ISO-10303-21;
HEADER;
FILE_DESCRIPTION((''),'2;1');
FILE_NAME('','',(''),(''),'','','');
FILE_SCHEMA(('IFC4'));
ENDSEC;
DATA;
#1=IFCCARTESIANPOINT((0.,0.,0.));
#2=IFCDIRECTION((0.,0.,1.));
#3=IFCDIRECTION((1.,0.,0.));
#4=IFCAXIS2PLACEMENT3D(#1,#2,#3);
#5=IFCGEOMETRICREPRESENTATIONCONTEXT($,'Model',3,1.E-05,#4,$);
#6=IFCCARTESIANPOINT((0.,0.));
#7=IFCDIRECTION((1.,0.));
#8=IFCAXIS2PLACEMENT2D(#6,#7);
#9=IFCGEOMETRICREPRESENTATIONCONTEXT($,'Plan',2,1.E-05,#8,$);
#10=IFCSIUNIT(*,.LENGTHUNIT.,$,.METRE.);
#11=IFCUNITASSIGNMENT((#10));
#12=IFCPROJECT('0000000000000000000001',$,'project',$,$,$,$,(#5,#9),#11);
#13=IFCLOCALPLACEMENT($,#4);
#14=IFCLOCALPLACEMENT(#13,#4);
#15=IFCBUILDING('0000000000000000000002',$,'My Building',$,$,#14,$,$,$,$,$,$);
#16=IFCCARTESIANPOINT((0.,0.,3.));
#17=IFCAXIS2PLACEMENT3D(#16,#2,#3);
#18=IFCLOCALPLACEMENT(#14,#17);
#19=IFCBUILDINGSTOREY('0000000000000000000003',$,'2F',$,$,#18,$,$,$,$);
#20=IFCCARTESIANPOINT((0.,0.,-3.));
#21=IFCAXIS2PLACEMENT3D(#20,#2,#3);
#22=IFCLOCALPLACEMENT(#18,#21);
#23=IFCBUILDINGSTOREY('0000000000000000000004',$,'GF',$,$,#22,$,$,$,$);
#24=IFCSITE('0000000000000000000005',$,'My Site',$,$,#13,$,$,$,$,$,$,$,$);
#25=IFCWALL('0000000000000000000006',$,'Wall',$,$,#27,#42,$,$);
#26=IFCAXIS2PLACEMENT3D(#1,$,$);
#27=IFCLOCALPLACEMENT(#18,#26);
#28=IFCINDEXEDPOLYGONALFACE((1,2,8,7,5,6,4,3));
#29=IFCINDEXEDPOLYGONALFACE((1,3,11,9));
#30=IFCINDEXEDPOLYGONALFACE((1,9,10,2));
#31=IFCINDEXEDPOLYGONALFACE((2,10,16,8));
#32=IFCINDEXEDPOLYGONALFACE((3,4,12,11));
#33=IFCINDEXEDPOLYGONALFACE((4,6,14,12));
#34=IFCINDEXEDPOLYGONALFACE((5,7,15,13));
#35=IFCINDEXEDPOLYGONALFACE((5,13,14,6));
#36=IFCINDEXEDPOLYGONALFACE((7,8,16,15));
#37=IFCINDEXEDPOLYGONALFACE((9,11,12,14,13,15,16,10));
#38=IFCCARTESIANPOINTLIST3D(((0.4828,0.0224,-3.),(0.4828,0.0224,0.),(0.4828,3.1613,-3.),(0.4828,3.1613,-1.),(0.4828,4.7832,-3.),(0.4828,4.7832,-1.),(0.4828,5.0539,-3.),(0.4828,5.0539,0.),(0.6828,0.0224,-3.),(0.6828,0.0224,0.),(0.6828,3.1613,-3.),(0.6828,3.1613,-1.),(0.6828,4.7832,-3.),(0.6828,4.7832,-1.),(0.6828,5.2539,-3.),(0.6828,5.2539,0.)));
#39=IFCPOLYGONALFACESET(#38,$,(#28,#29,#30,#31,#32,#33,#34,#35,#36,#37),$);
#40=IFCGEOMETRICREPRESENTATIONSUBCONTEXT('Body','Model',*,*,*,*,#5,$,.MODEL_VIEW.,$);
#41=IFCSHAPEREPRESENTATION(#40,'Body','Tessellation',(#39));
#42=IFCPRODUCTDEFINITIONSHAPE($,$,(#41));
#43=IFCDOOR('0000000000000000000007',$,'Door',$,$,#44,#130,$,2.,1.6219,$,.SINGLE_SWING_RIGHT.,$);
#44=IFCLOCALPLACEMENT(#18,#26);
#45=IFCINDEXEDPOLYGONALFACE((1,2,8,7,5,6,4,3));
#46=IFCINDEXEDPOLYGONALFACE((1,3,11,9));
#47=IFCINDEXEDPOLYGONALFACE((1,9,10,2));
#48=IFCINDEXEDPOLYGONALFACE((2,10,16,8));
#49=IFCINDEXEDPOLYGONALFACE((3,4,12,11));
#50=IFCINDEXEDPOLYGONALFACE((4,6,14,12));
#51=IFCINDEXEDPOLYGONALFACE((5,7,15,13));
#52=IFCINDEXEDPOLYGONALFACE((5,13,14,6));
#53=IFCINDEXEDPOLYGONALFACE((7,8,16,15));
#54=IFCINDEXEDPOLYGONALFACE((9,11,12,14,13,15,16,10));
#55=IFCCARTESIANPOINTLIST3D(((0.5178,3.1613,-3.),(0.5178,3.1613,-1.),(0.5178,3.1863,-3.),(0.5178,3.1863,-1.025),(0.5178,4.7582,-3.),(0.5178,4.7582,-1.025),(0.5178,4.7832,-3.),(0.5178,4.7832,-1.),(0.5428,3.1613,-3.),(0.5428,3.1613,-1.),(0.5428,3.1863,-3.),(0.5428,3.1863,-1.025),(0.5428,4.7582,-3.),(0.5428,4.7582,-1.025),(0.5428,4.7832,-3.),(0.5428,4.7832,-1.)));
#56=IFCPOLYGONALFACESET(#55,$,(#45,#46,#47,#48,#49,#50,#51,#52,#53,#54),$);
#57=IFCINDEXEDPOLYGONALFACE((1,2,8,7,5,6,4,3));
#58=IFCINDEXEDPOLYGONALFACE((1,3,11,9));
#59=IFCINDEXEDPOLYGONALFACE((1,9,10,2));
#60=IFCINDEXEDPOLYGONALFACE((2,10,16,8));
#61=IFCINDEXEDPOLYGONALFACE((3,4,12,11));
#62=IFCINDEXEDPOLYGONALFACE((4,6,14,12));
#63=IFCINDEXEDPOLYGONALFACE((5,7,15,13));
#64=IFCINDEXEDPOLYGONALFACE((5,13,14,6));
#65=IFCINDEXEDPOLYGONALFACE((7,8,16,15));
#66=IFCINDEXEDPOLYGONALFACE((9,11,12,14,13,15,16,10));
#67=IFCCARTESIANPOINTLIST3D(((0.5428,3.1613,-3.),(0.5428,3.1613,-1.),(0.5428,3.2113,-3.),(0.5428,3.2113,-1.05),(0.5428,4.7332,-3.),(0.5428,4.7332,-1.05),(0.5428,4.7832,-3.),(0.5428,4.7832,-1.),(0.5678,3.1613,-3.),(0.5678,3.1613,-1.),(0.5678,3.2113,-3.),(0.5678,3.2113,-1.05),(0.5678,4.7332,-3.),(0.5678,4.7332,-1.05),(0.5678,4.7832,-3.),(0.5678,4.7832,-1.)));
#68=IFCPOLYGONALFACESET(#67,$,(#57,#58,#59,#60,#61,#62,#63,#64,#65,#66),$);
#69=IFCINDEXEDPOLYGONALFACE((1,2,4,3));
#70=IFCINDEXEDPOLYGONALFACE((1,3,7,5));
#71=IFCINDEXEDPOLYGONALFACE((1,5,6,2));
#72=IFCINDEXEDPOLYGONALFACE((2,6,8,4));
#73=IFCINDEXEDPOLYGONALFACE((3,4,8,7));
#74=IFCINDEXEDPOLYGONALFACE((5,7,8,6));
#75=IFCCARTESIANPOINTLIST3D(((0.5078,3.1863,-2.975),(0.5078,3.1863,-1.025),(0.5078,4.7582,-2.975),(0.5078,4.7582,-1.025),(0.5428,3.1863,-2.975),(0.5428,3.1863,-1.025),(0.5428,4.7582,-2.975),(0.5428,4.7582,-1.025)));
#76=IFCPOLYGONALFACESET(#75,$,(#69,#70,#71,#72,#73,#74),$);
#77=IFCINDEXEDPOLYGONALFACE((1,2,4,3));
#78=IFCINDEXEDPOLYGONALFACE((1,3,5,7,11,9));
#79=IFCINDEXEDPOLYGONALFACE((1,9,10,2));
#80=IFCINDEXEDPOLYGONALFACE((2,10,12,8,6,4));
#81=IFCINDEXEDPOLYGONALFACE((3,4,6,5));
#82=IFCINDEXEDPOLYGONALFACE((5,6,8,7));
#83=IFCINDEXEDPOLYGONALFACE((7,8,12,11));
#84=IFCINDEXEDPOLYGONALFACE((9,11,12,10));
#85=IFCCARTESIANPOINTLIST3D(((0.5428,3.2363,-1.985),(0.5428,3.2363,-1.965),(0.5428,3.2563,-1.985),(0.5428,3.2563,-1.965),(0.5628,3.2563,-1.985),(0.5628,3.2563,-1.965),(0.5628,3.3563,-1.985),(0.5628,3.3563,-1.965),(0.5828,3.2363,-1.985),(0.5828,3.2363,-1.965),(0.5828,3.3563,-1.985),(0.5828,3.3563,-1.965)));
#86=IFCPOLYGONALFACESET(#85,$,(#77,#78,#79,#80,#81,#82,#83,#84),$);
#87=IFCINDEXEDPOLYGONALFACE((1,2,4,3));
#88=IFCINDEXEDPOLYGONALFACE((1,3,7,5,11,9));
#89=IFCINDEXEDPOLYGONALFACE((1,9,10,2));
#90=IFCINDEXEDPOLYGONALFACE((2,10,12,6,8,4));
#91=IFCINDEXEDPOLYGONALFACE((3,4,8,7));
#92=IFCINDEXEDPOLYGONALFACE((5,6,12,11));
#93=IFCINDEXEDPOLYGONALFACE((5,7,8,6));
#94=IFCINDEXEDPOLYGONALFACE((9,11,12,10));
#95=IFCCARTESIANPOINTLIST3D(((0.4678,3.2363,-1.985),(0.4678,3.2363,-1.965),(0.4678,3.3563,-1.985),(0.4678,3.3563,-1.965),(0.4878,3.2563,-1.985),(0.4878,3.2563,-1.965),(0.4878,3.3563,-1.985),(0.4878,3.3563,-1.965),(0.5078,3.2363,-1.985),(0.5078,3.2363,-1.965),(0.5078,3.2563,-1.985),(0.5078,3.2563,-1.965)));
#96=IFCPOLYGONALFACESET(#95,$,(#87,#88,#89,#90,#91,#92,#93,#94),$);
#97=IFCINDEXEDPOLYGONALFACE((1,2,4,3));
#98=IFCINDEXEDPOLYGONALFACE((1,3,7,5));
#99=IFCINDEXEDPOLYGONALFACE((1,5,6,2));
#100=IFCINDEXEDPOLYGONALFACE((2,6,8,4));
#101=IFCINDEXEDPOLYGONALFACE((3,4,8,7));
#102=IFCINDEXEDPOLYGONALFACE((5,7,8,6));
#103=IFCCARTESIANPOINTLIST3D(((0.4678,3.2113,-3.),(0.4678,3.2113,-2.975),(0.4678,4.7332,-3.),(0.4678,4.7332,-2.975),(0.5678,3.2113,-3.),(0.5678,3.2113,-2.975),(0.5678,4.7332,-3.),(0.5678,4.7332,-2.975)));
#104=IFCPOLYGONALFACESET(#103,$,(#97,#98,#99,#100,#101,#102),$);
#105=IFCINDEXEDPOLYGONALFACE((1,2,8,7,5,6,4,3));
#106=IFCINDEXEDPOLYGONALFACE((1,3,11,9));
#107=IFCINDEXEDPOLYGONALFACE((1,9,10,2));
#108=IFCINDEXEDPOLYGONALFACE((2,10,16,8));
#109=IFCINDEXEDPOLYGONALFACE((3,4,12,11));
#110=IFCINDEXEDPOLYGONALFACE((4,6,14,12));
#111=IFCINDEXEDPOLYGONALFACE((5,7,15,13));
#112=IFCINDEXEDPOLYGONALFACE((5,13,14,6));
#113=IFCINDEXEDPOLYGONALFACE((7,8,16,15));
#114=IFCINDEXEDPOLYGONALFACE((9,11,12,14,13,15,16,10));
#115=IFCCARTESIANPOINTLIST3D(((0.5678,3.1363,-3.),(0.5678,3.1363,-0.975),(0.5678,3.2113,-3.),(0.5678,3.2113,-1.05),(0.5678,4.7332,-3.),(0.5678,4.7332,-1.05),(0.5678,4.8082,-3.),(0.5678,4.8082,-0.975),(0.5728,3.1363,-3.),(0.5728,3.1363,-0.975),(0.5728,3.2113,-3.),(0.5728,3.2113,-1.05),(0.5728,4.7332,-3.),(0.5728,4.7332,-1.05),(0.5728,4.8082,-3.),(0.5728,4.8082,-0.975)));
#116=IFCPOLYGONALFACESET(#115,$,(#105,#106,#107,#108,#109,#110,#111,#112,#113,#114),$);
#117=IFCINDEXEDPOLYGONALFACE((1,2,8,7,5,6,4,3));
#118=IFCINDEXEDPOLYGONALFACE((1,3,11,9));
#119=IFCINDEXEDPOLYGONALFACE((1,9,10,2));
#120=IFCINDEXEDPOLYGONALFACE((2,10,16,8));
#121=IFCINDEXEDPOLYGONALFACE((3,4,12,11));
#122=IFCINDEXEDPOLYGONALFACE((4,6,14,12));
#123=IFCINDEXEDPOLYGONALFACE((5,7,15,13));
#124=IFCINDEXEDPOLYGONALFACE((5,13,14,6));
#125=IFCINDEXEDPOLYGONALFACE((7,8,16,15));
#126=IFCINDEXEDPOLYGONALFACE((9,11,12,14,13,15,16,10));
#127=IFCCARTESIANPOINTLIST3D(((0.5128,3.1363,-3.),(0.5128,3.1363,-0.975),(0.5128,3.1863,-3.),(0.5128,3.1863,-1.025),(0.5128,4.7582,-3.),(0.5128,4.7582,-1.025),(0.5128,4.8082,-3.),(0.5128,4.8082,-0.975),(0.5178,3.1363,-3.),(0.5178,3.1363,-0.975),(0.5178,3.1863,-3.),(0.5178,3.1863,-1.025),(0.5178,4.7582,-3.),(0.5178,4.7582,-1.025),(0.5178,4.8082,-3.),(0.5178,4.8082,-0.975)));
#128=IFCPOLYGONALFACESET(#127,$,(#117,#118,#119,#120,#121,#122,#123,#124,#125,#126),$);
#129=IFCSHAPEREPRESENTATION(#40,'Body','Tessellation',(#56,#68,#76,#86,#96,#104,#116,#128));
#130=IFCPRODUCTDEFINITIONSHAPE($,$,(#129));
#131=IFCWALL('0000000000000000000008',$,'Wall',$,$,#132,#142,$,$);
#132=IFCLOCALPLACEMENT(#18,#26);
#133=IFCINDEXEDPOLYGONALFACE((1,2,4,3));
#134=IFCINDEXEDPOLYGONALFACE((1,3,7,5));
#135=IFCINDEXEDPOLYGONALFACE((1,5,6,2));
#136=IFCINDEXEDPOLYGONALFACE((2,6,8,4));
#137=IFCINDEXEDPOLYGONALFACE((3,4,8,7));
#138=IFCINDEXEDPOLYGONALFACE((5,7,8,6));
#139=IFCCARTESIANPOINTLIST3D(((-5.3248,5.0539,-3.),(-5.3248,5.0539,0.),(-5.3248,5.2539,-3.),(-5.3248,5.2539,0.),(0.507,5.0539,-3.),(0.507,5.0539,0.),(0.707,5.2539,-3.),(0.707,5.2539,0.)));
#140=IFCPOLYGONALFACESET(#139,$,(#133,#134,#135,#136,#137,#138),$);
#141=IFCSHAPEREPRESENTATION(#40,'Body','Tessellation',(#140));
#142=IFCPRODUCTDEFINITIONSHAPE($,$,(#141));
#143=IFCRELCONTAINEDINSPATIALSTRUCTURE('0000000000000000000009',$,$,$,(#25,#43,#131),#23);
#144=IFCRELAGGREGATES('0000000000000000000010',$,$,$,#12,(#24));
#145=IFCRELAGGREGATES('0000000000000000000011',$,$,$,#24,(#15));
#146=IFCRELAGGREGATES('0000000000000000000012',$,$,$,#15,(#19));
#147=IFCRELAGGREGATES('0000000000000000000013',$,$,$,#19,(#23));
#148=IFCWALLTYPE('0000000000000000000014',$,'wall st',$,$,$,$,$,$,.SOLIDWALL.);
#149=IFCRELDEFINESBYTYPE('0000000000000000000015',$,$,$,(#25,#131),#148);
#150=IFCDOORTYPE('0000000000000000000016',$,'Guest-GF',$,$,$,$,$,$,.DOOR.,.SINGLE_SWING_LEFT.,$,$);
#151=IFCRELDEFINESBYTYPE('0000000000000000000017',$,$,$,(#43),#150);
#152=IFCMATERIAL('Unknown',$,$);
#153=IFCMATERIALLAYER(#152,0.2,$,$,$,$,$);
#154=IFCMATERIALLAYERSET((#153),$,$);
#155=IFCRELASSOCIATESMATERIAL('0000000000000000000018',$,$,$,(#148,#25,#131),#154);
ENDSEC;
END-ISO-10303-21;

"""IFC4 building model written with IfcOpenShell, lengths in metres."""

from ifc_helpers import new_model, entity, si_unit, frame, origin_with_axes, origin_2d_with_axis, place, context, subcontext, project, spatial, line, indexed_curve, outline, extrude, shape, source, transform, mapped, material, layer, layer_set, layer_usage, type_object, type_shapes, element, fill, save


model = new_model("IFC4")

# Units and contexts
model_context = context("Model", 3, precision=1e-05, world=origin_with_axes())
plan_context = context("Plan", 2, precision=1e-05, world=origin_2d_with_axis())
body_context_1 = subcontext(model_context, "Body", "Model", "MODEL_VIEW")
body_context_2 = subcontext(plan_context, "Body", "Plan", "PLAN_VIEW")
ifc_project = project(units=[si_unit("LENGTHUNIT", "METRE")], contexts=[model_context, plan_context])

# Site, building, storeys
site_placement = place(None, origin_with_axes())
site = spatial("IfcSite", under=ifc_project, at=site_placement, Name="My Site")
building_placement = place(site_placement, origin_with_axes())
building = spatial("IfcBuilding", under=site, at=building_placement, Name="My Building")
storey_1_placement = place(building_placement, frame((0.0, 0.0, 3.0), z_axis=(0.0, 0.0, 1.0), x_axis=(1.0, 0.0, 0.0)))
storey_1 = spatial("IfcBuildingStorey", under=building, at=storey_1_placement, Name="2F")
storey_2_placement = place(storey_1_placement, frame((0.0, 0.0, -3.0), z_axis=(0.0, 0.0, 1.0), x_axis=(1.0, 0.0, 0.0)))
storey_2 = spatial("IfcBuildingStorey", under=storey_1, at=storey_2_placement, Name="GF")

# Shared definitions
ifc_material = material(Name="Unknown")

# Shared definitions
ifc_layer_1 = layer(ifc_material, 0.2)
ifc_layer_set_1 = layer_set([ifc_layer_1])
wall_type = type_object("IfcWallType", Name="wall st", PredefinedType="SOLIDWALL", material=ifc_layer_set_1)

# Wall, opening, door
ifc_layer_usage_1 = layer_usage(ifc_layer_set_1, "AXIS2", "POSITIVE", 0.0)
wall_1_placement = place(storey_2_placement, frame((0.6828, -0.1776, 0.0), z_axis=(0.0, 0.0, 1.0), x_axis=(0.0, 1.0, 0.0)))
wall_1 = element("IfcWall", 1, at=wall_1_placement, inside=storey_2, type_object=wall_type, material=ifc_layer_usage_1, Name="Wall", context=body_context_1, shape_type="SweptSolid", body=[
    extrude(outline(indexed_curve([(0.2, 0.0), (0.2, 0.2), (5.2316, 0.2), (5.4316, 0.0)], segments=[line(1, 2, 3, 4, 1)])), origin_with_axes(), (0.0, 0.0, 1.0), 3.0),
])
shared_shape_1 = source(origin_with_axes(), body_context_1, "Body", "SweptSolid", [
    extrude(outline(indexed_curve([(0.0, 0.0), (1.6219, 0.0), (1.6219, 2.0), (0.0, 2.0)], segments=[line(1, 2, 3, 4, 1)])), frame((0.0, -0.6, 0.0), z_axis=(0.0, -1.0, 0.0), x_axis=(1.0, 0.0, 0.0)), (0.0, 0.0, -1.0), 1.2),
])
opening_1_placement = place(wall_1_placement, frame((3.3389, 0.115, 0.0), z_axis=(0.0, 0.0, 1.0), x_axis=(1.0, 0.0, 0.0)))
opening_1 = element("IfcOpeningElement", 2, at=opening_1_placement, cuts=wall_1, PredefinedType="OPENING", context=body_context_1, shape_type="MappedRepresentation", body=[
    mapped(shared_shape_1, transform((0.0, 0.0, 0.0), x_axis=(1.0, 0.0, 0.0), y_axis=(0.0, 1.0, 0.0), z_axis=(0.0, 0.0, 1.0), scale=1.0)),
])
door_type_1 = type_object("IfcDoorType", Name="Guest-GF", OperationType="SINGLE_SWING_LEFT", PredefinedType="DOOR")
shared_shape_2 = source(origin_with_axes(), body_context_1, "Body", "SweptSolid", [
    extrude(outline(indexed_curve([(0.0, 0.0), (0.0, 2.0), (1.6219, 2.0), (1.6219, 0.0), (1.5969, 0.0), (1.5969, 1.975), (0.025, 1.975), (0.025, 0.0)], segments=[line(1, 2, 3, 4, 5, 6, 7, 8, 1)])), frame((0.0, 0.025, 0.0), z_axis=(0.0, -1.0, 0.0), x_axis=(1.0, 0.0, 0.0)), (0.0, 0.0, -1.0), 0.025),
    extrude(outline(indexed_curve([(0.0, 0.0), (0.0, 2.0), (1.6219, 2.0), (1.6219, 0.0), (1.5719, 0.0), (1.5719, 1.95), (0.05, 1.95), (0.05, 0.0)], segments=[line(1, 2, 3, 4, 5, 6, 7, 8, 1)])), frame((0.0, 0.0, 0.0), z_axis=(0.0, -1.0, 0.0), x_axis=(1.0, 0.0, 0.0)), (0.0, 0.0, -1.0), 0.025),
    extrude(outline(indexed_curve([(0.0, 0.0), (1.5719, 0.0), (1.5719, 0.035), (0.0, 0.035)], segments=[line(1, 2, 3, 4, 1)])), frame((0.025, 0.025, 0.025), z_axis=(0.0, 0.0, 1.0), x_axis=(1.0, 0.0, 0.0)), (0.0, 0.0, 1.0), 1.95),
    extrude(outline(indexed_curve([(0.0, 0.0), (0.0, -0.04), (0.12, -0.04), (0.12, -0.02), (0.02, -0.02), (0.02, 0.0)], segments=[line(1, 2, 3, 4, 5, 6, 1)])), frame((0.075, 0.025, 1.015), z_axis=(0.0, 0.0, 1.0), x_axis=(1.0, 0.0, 0.0)), (0.0, 0.0, 1.0), 0.02),
    extrude(outline(indexed_curve([(0.0, 0.0), (0.0, 0.04), (0.12, 0.04), (0.12, 0.02), (0.02, 0.02), (0.02, 0.0)], segments=[line(1, 2, 3, 4, 5, 6, 1)])), frame((0.075, 0.06, 1.015), z_axis=(0.0, 0.0, 1.0), x_axis=(1.0, 0.0, 0.0)), (0.0, 0.0, 1.0), 0.02),
    extrude(outline(indexed_curve([(0.0, 0.0), (1.5219, 0.0), (1.5219, 0.1), (0.0, 0.1)], segments=[line(1, 2, 3, 4, 1)])), frame((0.05, 0.0, 0.0), z_axis=(0.0, 0.0, 1.0), x_axis=(1.0, 0.0, 0.0)), (0.0, 0.0, 1.0), 0.025),
    extrude(outline(indexed_curve([(0.0, 0.0), (0.0, 2.025), (1.6719, 2.025), (1.6719, 0.0), (1.5969, 0.0), (1.5969, 1.95), (0.075, 1.95), (0.075, 0.0)], segments=[line(1, 2, 3, 4, 5, 6, 7, 8, 1)])), frame((-0.025, -0.005, 0.0), z_axis=(0.0, -1.0, 0.0), x_axis=(1.0, 0.0, 0.0)), (0.0, 0.0, -1.0), 0.005),
    extrude(outline(indexed_curve([(0.0, 0.0), (0.0, 2.025), (1.6719, 2.025), (1.6719, 0.0), (1.6219, 0.0), (1.6219, 1.975), (0.05, 1.975), (0.05, 0.0)], segments=[line(1, 2, 3, 4, 5, 6, 7, 8, 1)])), frame((-0.025, 0.05, 0.0), z_axis=(0.0, -1.0, 0.0), x_axis=(1.0, 0.0, 0.0)), (0.0, 0.0, -1.0), 0.005),
])
shared_shape_3 = source(origin_with_axes(), body_context_2, "Body", "Curve2D", [
    entity("IfcIndexedPolyCurve", entity("IfcCartesianPointList2D", [[0.0, 0.0], [0.0, 0.05], [0.025, 0.05], [0.025, 0.025], [0.05, 0.025], [0.05, 0.0]]), [entity("IfcLineIndex", [1, 2, 3, 4, 5, 6, 1])]),
    entity("IfcIndexedPolyCurve", entity("IfcCartesianPointList2D", [[1.6219, 0.0], [1.6219, 0.05], [1.5969, 0.05], [1.5969, 0.025], [1.5719, 0.025], [1.5719, 0.0]]), [entity("IfcLineIndex", [1, 2, 3, 4, 5, 6, 1])]),
    entity("IfcTrimmedCurve", entity("IfcEllipse", entity("IfcAxis2Placement2D", entity("IfcCartesianPoint", [1.5619, 0.05]), entity("IfcDirection", [1.0, 0.0])), 1.5369, 1.5719), [entity("IfcCartesianPoint", [1.5619, 1.6219])], [entity("IfcCartesianPoint", [0.025, 0.05])], True, "CARTESIAN"),
    entity("IfcIndexedPolyCurve", entity("IfcCartesianPointList2D", [[1.5969, 0.05], [1.5619, 0.05], [1.5619, 1.6219], [1.5969, 1.6219]]), [entity("IfcLineIndex", [1, 2, 3, 4, 1])]),
])
type_shapes(door_type_1, [shared_shape_2, shared_shape_3])
door_1_placement = place(opening_1_placement, frame((0.0, 0.0, 0.0), z_axis=(0.0, 0.0, 1.0), x_axis=(1.0, 0.0, 0.0)))
door_1 = element("IfcDoor", 3, at=door_1_placement, inside=storey_2, type_object=door_type_1, Name="Door", OperationType="SINGLE_SWING_RIGHT", OverallHeight=2.0, OverallWidth=1.6219, shapes=[
    shape(body_context_1, "Body", "MappedRepresentation", [mapped(shared_shape_2, transform((0.0, 0.0, 0.0), x_axis=(1.0, 0.0, 0.0), y_axis=(0.0, 1.0, 0.0), z_axis=(0.0, 0.0, 1.0), scale=1.0))]),
    shape(body_context_2, "Body", "MappedRepresentation", [mapped(shared_shape_3, transform((0.0, 0.0, 0.0), x_axis=(1.0, 0.0, 0.0), y_axis=(0.0, 1.0, 0.0), z_axis=(0.0, 0.0, 1.0), scale=1.0))]),
])
fill(opening_1, door_1)

# Wall
ifc_layer_usage_2 = layer_usage(ifc_layer_set_1, "AXIS2", "POSITIVE", 0.0)
wall_2_placement = place(storey_2_placement, frame((-5.5248, 5.0539, 0.0), z_axis=(0.0, 0.0, 1.0), x_axis=(1.0, 0.0, 0.0)))
element("IfcWall", 4, at=wall_2_placement, inside=storey_2, type_object=wall_type, material=ifc_layer_usage_2, Name="Wall", context=body_context_1, shape_type="SweptSolid", body=[
    extrude(outline(indexed_curve([(0.2, 0.0), (0.2, 0.2), (6.2318, 0.2), (6.0318, 0.0)], segments=[line(1, 2, 3, 4, 1)])), origin_with_axes(), (0.0, 0.0, 1.0), 3.0),
])

save(model, "model.ifc")
